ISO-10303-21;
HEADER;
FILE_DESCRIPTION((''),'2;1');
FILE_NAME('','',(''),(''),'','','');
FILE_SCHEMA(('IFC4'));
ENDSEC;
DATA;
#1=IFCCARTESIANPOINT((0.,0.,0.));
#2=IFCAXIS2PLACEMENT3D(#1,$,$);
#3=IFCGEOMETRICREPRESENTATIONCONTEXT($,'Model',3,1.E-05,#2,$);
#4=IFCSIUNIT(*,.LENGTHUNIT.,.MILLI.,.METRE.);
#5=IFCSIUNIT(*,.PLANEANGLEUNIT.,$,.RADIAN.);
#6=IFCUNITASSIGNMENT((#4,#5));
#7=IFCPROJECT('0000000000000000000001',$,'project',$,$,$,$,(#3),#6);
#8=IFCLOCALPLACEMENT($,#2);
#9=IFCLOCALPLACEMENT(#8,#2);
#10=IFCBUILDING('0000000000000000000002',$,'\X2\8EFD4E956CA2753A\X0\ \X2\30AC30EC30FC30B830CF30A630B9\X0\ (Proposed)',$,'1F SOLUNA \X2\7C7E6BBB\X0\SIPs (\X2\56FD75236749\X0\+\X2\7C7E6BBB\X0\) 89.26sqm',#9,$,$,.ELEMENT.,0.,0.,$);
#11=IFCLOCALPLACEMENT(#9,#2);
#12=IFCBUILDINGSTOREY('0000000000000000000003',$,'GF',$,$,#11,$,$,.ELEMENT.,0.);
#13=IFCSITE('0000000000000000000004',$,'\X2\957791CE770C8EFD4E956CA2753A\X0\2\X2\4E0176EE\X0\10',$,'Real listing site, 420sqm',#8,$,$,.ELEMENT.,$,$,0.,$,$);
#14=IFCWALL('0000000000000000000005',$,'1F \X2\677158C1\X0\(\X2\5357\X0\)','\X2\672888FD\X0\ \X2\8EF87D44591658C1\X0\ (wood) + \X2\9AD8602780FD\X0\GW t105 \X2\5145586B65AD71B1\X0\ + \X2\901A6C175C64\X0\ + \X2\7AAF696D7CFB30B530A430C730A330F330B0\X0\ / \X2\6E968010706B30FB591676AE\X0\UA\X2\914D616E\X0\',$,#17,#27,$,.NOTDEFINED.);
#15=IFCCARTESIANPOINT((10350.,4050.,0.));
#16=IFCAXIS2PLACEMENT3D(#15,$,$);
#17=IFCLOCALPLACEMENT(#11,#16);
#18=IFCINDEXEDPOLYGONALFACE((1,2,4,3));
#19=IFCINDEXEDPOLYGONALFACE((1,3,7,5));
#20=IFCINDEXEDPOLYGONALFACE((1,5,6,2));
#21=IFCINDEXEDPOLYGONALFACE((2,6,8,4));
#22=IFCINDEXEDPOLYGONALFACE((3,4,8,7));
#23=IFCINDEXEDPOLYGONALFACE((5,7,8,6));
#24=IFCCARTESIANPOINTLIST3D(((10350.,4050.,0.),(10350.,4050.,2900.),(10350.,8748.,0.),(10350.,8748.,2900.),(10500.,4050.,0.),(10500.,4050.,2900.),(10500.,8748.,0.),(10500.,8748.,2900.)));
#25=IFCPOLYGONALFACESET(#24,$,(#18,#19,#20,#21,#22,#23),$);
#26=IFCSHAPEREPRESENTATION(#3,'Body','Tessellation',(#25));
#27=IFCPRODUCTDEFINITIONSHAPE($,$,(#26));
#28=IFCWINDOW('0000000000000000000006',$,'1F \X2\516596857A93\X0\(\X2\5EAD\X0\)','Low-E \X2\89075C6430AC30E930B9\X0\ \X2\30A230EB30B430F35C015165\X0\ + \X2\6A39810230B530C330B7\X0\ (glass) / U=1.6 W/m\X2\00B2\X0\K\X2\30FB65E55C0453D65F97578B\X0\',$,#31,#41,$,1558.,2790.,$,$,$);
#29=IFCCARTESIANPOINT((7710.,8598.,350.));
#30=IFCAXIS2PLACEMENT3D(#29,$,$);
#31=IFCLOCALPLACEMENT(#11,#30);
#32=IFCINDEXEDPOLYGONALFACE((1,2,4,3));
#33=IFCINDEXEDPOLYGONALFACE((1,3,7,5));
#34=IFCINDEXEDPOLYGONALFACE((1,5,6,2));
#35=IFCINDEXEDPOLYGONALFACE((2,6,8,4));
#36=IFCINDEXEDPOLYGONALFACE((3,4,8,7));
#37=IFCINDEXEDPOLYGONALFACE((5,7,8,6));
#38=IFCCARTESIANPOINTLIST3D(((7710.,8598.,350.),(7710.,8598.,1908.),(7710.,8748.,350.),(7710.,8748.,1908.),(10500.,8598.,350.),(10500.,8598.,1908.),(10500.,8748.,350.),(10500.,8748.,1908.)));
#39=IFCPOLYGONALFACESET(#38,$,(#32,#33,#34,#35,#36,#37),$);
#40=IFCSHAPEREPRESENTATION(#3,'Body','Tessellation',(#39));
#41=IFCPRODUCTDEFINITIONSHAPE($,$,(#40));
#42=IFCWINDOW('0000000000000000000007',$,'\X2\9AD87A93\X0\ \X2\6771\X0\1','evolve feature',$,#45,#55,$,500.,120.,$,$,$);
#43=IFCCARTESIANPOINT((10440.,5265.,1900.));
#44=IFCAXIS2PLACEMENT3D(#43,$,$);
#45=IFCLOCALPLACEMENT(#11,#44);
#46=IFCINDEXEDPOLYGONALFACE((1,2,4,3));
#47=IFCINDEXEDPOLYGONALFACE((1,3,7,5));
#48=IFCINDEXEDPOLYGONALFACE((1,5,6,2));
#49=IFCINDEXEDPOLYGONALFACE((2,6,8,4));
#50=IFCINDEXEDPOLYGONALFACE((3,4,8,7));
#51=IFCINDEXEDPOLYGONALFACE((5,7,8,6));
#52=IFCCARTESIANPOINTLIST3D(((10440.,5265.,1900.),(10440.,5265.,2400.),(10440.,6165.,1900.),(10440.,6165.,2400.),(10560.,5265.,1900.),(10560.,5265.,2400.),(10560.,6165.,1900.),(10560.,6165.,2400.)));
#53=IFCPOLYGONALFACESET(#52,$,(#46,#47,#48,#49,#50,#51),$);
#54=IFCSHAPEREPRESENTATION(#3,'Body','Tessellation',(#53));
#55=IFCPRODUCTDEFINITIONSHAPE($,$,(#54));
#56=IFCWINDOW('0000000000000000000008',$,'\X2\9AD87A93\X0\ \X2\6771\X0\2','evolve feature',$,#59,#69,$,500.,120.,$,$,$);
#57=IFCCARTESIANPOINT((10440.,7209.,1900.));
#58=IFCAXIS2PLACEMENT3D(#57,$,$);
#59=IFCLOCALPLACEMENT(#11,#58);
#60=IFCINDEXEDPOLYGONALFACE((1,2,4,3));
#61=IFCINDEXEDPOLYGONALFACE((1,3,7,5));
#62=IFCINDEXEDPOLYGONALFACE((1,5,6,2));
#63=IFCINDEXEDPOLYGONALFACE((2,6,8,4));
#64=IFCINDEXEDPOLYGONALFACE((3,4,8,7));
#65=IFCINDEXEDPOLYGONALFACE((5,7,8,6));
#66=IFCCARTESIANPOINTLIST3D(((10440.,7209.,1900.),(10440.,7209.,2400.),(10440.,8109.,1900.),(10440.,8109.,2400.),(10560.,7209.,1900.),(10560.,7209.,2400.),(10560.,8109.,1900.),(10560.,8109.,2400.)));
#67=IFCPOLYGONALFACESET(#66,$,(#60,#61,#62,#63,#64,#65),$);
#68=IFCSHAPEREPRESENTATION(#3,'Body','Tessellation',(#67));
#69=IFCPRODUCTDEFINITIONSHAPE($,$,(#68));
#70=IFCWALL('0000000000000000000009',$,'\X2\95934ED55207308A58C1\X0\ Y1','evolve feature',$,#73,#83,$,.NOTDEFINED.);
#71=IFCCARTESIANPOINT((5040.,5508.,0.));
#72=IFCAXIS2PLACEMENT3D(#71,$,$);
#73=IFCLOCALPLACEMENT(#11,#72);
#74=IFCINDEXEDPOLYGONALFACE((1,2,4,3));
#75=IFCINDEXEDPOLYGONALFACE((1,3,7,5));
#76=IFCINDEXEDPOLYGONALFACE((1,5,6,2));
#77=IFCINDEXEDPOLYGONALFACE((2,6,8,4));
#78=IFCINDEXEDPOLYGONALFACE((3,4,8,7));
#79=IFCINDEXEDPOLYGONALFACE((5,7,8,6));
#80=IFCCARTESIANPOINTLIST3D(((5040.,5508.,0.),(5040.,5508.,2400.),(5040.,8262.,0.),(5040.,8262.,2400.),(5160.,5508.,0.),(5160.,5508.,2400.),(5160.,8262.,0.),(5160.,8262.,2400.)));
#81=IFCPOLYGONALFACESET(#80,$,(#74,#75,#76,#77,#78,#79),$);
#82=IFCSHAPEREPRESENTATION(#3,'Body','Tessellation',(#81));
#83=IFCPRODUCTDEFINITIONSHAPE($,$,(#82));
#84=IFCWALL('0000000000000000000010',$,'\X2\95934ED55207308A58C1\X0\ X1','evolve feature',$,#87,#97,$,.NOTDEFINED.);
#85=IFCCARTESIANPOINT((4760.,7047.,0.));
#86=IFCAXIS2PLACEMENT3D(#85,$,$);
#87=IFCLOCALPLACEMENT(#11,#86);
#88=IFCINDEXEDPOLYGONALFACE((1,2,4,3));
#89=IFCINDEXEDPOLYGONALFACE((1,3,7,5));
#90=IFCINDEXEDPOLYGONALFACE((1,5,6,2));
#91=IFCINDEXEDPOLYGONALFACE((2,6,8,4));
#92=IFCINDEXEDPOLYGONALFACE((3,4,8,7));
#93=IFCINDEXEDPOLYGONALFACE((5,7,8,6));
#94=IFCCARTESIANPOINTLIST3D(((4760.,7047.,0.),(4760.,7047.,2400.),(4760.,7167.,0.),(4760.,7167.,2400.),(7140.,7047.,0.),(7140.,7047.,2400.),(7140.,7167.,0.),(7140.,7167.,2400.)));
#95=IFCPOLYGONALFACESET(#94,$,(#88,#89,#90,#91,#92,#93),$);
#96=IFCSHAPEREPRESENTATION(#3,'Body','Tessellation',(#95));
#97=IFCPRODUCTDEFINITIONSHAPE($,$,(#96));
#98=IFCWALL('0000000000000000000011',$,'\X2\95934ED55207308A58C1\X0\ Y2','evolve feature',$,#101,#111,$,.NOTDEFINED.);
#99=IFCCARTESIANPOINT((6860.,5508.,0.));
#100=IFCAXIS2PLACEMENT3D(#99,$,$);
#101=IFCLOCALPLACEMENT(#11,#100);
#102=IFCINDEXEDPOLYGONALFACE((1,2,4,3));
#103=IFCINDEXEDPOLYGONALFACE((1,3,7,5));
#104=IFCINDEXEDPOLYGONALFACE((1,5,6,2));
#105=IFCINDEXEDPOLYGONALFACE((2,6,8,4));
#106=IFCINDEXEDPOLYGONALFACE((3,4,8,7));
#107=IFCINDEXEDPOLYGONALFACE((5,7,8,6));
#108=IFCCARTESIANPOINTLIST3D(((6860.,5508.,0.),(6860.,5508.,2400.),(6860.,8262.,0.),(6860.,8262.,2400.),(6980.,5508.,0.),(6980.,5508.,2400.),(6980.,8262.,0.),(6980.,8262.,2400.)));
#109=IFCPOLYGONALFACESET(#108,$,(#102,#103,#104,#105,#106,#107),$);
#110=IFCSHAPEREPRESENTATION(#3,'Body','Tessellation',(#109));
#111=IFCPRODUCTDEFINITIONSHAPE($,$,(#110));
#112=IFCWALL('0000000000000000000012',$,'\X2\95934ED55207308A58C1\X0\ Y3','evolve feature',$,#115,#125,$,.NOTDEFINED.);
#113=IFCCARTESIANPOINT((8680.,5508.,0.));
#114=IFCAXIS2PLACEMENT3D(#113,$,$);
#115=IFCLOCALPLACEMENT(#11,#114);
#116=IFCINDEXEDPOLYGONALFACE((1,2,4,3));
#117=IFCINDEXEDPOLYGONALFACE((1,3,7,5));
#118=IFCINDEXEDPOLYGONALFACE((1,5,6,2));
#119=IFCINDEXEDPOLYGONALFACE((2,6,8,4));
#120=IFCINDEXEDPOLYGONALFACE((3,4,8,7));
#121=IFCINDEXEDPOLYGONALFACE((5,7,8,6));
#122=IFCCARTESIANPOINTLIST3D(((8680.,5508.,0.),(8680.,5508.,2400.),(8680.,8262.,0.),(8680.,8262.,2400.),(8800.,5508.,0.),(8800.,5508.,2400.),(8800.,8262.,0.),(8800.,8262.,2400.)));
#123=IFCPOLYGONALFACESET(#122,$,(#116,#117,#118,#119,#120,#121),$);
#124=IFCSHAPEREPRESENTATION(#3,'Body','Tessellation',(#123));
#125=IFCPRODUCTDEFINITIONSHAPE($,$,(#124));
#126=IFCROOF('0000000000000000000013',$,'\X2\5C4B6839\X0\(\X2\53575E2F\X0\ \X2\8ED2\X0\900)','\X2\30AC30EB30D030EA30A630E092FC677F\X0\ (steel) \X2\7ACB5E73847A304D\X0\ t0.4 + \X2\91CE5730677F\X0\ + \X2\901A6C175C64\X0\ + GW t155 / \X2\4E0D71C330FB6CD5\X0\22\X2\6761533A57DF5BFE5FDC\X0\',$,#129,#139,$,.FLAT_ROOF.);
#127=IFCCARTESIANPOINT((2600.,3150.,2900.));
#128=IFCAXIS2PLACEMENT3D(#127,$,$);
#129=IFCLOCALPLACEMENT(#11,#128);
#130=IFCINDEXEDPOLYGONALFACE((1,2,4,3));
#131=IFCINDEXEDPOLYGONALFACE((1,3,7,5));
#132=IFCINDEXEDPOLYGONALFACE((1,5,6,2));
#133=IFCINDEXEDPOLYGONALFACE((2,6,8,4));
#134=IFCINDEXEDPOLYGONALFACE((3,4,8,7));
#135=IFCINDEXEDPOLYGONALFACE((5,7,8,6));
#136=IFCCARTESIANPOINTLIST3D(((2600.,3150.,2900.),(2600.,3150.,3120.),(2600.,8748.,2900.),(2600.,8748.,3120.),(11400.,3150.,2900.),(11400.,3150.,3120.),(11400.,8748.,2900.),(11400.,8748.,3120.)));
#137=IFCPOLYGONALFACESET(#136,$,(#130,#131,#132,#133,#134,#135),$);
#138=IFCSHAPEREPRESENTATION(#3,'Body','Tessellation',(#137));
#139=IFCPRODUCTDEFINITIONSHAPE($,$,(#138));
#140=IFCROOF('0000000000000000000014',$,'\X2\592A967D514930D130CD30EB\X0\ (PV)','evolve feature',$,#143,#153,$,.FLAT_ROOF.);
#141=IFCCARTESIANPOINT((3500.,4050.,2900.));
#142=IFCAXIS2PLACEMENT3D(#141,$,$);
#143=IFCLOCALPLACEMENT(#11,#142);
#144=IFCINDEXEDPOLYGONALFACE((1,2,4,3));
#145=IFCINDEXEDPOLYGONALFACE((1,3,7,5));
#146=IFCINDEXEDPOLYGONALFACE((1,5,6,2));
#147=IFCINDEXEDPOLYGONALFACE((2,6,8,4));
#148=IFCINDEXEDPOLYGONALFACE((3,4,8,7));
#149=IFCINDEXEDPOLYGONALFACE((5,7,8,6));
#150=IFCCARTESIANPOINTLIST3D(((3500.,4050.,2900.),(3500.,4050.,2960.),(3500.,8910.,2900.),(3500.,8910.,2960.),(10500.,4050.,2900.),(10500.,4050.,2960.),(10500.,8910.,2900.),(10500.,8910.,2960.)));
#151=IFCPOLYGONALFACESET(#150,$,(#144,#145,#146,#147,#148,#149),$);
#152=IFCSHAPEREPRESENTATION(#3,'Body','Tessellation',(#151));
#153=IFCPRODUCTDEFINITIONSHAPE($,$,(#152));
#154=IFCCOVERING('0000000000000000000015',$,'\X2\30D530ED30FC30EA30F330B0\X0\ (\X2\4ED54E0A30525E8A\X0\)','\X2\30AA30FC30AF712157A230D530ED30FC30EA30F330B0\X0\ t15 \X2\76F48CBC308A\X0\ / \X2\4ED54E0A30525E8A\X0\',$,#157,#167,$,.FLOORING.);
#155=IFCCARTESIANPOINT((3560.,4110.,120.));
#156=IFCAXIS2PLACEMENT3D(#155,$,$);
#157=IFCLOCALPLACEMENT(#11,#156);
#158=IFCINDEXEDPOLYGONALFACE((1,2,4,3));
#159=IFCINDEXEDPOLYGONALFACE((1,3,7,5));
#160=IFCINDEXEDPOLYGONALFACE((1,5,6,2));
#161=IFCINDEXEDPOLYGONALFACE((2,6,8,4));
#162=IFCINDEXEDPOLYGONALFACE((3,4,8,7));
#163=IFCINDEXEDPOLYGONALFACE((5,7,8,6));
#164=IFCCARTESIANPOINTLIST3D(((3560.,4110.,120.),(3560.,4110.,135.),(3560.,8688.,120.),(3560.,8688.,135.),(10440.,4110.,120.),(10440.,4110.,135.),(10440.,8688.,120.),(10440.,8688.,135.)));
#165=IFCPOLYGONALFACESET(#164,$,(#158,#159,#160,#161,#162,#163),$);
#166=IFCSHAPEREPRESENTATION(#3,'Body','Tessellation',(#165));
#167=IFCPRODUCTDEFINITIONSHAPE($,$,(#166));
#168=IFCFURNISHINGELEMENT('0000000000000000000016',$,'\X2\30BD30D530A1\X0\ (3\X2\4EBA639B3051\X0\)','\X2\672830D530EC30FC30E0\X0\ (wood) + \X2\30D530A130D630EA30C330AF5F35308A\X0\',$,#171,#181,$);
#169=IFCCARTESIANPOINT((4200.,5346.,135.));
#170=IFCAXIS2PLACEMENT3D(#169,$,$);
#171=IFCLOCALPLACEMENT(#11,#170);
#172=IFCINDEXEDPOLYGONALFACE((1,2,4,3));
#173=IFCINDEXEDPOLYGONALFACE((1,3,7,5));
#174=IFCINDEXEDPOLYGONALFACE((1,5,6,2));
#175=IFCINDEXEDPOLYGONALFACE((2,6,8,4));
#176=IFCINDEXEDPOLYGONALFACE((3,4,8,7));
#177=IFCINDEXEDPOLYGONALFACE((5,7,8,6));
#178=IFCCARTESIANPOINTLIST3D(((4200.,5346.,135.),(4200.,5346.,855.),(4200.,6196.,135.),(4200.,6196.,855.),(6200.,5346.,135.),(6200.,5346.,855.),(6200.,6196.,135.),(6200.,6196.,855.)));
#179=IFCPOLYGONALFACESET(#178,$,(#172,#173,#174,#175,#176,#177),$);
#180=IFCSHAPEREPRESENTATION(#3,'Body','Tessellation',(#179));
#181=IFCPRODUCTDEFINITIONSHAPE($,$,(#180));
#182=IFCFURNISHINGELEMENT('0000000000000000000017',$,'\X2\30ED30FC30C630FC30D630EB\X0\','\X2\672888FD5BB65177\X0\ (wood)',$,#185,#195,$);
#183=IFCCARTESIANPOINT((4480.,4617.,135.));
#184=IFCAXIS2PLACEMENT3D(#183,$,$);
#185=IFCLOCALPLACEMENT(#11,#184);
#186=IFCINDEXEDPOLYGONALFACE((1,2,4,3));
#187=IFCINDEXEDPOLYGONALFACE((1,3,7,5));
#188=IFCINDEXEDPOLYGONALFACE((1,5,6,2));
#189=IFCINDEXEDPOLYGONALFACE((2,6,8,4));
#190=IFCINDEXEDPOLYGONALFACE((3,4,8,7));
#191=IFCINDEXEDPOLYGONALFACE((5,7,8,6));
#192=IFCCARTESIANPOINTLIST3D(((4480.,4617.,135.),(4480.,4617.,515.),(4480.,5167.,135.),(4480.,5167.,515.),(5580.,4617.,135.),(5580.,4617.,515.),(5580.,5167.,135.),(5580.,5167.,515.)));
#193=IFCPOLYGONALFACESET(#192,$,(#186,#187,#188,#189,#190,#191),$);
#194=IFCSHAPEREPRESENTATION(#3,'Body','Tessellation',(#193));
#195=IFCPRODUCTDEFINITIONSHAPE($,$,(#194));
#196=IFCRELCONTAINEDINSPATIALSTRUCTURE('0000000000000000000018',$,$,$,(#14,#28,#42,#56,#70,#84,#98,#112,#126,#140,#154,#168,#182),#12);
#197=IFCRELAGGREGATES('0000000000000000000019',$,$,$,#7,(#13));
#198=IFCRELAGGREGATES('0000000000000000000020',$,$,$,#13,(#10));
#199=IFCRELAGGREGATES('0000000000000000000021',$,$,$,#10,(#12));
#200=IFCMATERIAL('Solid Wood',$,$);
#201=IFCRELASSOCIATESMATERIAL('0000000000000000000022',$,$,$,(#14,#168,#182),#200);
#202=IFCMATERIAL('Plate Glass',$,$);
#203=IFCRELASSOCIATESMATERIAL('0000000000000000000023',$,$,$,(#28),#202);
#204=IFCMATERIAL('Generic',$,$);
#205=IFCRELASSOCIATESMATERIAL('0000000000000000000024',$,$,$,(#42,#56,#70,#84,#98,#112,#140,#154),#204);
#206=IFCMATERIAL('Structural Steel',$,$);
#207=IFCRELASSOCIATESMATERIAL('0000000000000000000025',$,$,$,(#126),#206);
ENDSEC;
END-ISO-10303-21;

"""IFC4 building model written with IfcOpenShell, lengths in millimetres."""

from ifc_helpers import new_model, si_unit, frame, frame_2d, origin, place, context, project, spatial, rectangle, extrude, material, element, fill, save


model = new_model("IFC4")

# Units and contexts
model_context = context("Model", 3, precision=1e-05, world=origin())
ifc_project = project(units=[si_unit("LENGTHUNIT", "METRE", prefix="MILLI"), si_unit("PLANEANGLEUNIT", "RADIAN")], contexts=[model_context])

# Site, building, storey
site_placement = place(None, origin())
site = spatial("IfcSite", under=ifc_project, at=site_placement, Name="長野県軽井沢町2丁目10", ObjectType="Real listing site, 420sqm", CompositionType="ELEMENT", RefElevation=0.0)
building_placement = place(site_placement, origin())
building = spatial("IfcBuilding", under=site, at=building_placement, Name="軽井沢町 ガレージハウス (Proposed)", ObjectType="1F SOLUNA 籾殻SIPs (国産杉+籾殻) 89.26sqm", CompositionType="ELEMENT", ElevationOfRefHeight=0.0, ElevationOfTerrain=0.0)
storey_placement = place(building_placement, origin())
storey = spatial("IfcBuildingStorey", under=building, at=storey_placement, Name="GF", CompositionType="ELEMENT", Elevation=0.0)

# Shared definitions
ifc_material_1 = material(Name="Solid Wood")
ifc_material_2 = material(Name="Generic")

# Shared definitions
ifc_material_3 = material(Name="Plate Glass")

# Wall, openings, windows
wall_1_placement = place(storey_placement, frame((10350.0, 4050.0, 0.0)))
wall_1 = element("IfcWall", 1, at=wall_1_placement, inside=storey, material=ifc_material_1, Name="1F 東壁(南)", Description="木製 軸組外壁 (wood) + 高性能GW t105 充填断熱 + 通気層 + 窯業系サイディング / 準耐火・外皮UA配慮", PredefinedType="NOTDEFINED", context=model_context, shape_type="SweptSolid", body=[
    extrude(rectangle(XDim=150.0, YDim=4698.0, at=frame_2d((75.0, 2349.0))), frame((10350.0, 4050.0, 0.0)), (0.0, 0.0, 1.0), 2900.0),
])
opening_1_placement = place(storey_placement, frame((7710.0, 8598.0, 350.0)))
opening_1 = element("IfcOpeningElement", 2, at=opening_1_placement, cuts=wall_1, PredefinedType="NOTDEFINED", context=model_context, shape_type="SweptSolid", body=[
    extrude(rectangle(XDim=2790.0, YDim=150.0, at=frame_2d((1395.0, 75.0))), frame((7710.0, 8598.0, 350.0)), (0.0, 0.0, 1.0), 1558.0),
])
opening_2_placement = place(storey_placement, frame((10440.0, 5265.0, 1900.0)))
opening_2 = element("IfcOpeningElement", 3, at=opening_2_placement, cuts=wall_1, PredefinedType="NOTDEFINED", context=model_context, shape_type="SweptSolid", body=[
    extrude(rectangle(XDim=120.0, YDim=900.0, at=frame_2d((60.0, 450.0))), frame((10440.0, 5265.0, 1900.0)), (0.0, 0.0, 1.0), 500.0),
])
opening_3_placement = place(storey_placement, frame((10440.0, 7209.0, 1900.0)))
opening_3 = element("IfcOpeningElement", 4, at=opening_3_placement, cuts=wall_1, PredefinedType="NOTDEFINED", context=model_context, shape_type="SweptSolid", body=[
    extrude(rectangle(XDim=120.0, YDim=900.0, at=frame_2d((60.0, 450.0))), frame((10440.0, 7209.0, 1900.0)), (0.0, 0.0, 1.0), 500.0),
])
window_1_placement = place(storey_placement, frame((7710.0, 8598.0, 350.0)))
window_1 = element("IfcWindow", 5, at=window_1_placement, inside=storey, material=ifc_material_3, Name="1F 入隅窓(庭)", Description="Low-E 複層ガラス アルゴン封入 + 樹脂サッシ (glass) / U=1.6 W/m²K・日射取得型", OverallHeight=1558.0, OverallWidth=2790.0, context=model_context, shape_type="SweptSolid", body=[
    extrude(rectangle(XDim=2790.0, YDim=150.0, at=frame_2d((1395.0, 75.0))), frame((7710.0, 8598.0, 350.0)), (0.0, 0.0, 1.0), 1558.0),
])
fill(opening_1, window_1)
window_2_placement = place(storey_placement, frame((10440.0, 5265.0, 1900.0)))
window_2 = element("IfcWindow", 6, at=window_2_placement, inside=storey, material=ifc_material_2, Name="高窓 東1", Description="evolve feature", OverallHeight=500.0, OverallWidth=120.0, context=model_context, shape_type="SweptSolid", body=[
    extrude(rectangle(XDim=120.0, YDim=900.0, at=frame_2d((60.0, 450.0))), frame((10440.0, 5265.0, 1900.0)), (0.0, 0.0, 1.0), 500.0),
])
fill(opening_2, window_2)
window_3_placement = place(storey_placement, frame((10440.0, 7209.0, 1900.0)))
window_3 = element("IfcWindow", 7, at=window_3_placement, inside=storey, material=ifc_material_2, Name="高窓 東2", Description="evolve feature", OverallHeight=500.0, OverallWidth=120.0, context=model_context, shape_type="SweptSolid", body=[
    extrude(rectangle(XDim=120.0, YDim=900.0, at=frame_2d((60.0, 450.0))), frame((10440.0, 7209.0, 1900.0)), (0.0, 0.0, 1.0), 500.0),
])
fill(opening_3, window_3)

# Walls
wall_2_placement = place(storey_placement, frame((5040.0, 5508.0, 0.0)))
element("IfcWall", 8, at=wall_2_placement, inside=storey, material=ifc_material_2, Name="間仕切り壁 Y1", Description="evolve feature", PredefinedType="NOTDEFINED", context=model_context, shape_type="SweptSolid", body=[
    extrude(rectangle(XDim=120.0, YDim=2754.0, at=frame_2d((60.0, 1377.0))), frame((5040.0, 5508.0, 0.0)), (0.0, 0.0, 1.0), 2400.0),
])
wall_3_placement = place(storey_placement, frame((4760.0, 7047.0, 0.0)))
element("IfcWall", 9, at=wall_3_placement, inside=storey, material=ifc_material_2, Name="間仕切り壁 X1", Description="evolve feature", PredefinedType="NOTDEFINED", context=model_context, shape_type="SweptSolid", body=[
    extrude(rectangle(XDim=2380.0, YDim=120.0, at=frame_2d((1190.0, 60.0))), frame((4760.0, 7047.0, 0.0)), (0.0, 0.0, 1.0), 2400.0),
])
wall_4_placement = place(storey_placement, frame((6860.0, 5508.0, 0.0)))
element("IfcWall", 10, at=wall_4_placement, inside=storey, material=ifc_material_2, Name="間仕切り壁 Y2", Description="evolve feature", PredefinedType="NOTDEFINED", context=model_context, shape_type="SweptSolid", body=[
    extrude(rectangle(XDim=120.0, YDim=2754.0, at=frame_2d((60.0, 1377.0))), frame((6860.0, 5508.0, 0.0)), (0.0, 0.0, 1.0), 2400.0),
])
wall_5_placement = place(storey_placement, frame((8680.0, 5508.0, 0.0)))
element("IfcWall", 11, at=wall_5_placement, inside=storey, material=ifc_material_2, Name="間仕切り壁 Y3", Description="evolve feature", PredefinedType="NOTDEFINED", context=model_context, shape_type="SweptSolid", body=[
    extrude(rectangle(XDim=120.0, YDim=2754.0, at=frame_2d((60.0, 1377.0))), frame((8680.0, 5508.0, 0.0)), (0.0, 0.0, 1.0), 2400.0),
])

# Roofs
ifc_material_4 = material(Name="Structural Steel")
roof_1_placement = place(storey_placement, frame((2600.0, 3150.0, 2900.0)))
element("IfcRoof", 12, at=roof_1_placement, inside=storey, material=ifc_material_4, Name="屋根(南帯 軒900)", Description="ガルバリウム鋼板 (steel) 立平葺き t0.4 + 野地板 + 通気層 + GW t155 / 不燃・法22条区域対応", PredefinedType="FLAT_ROOF", context=model_context, shape_type="SweptSolid", body=[
    extrude(rectangle(XDim=8800.0, YDim=5598.0, at=frame_2d((4400.0, 2799.0))), frame((2600.0, 3150.0, 2900.0)), (0.0, 0.0, 1.0), 220.0),
])
roof_2_placement = place(storey_placement, frame((3500.0, 4050.0, 2900.0)))
element("IfcRoof", 13, at=roof_2_placement, inside=storey, material=ifc_material_2, Name="太陽光パネル (PV)", Description="evolve feature", PredefinedType="FLAT_ROOF", context=model_context, shape_type="SweptSolid", body=[
    extrude(rectangle(XDim=7000.0, YDim=4860.0, at=frame_2d((3500.0, 2430.0))), frame((3500.0, 4050.0, 2900.0)), (0.0, 0.0, 1.0), 60.0),
])

# Covering
covering_placement = place(storey_placement, frame((3560.0, 4110.0, 120.0)))
element("IfcCovering", 14, at=covering_placement, inside=storey, material=ifc_material_2, Name="フローリング (仕上げ床)", Description="オーク無垢フローリング t15 直貼り / 仕上げ床", PredefinedType="FLOORING", context=model_context, shape_type="SweptSolid", body=[
    extrude(rectangle(XDim=6880.0, YDim=4578.0, at=frame_2d((3440.0, 2289.0))), frame((3560.0, 4110.0, 120.0)), (0.0, 0.0, 1.0), 15.0),
])

# Furnishing elements
furnishing_1_placement = place(storey_placement, frame((4200.0, 5346.0, 135.0)))
element("IfcFurnishingElement", 15, at=furnishing_1_placement, inside=storey, material=ifc_material_1, Name="ソファ (3人掛け)", Description="木フレーム (wood) + ファブリック張り", context=model_context, shape_type="SweptSolid", body=[
    extrude(rectangle(XDim=2000.0, YDim=850.0, at=frame_2d((1000.0, 425.0))), frame((4200.0, 5346.0, 135.0)), (0.0, 0.0, 1.0), 720.0),
])
furnishing_2_placement = place(storey_placement, frame((4480.0, 4617.0, 135.0)))
element("IfcFurnishingElement", 16, at=furnishing_2_placement, inside=storey, material=ifc_material_1, Name="ローテーブル", Description="木製家具 (wood)", context=model_context, shape_type="SweptSolid", body=[
    extrude(rectangle(XDim=1100.0, YDim=550.0, at=frame_2d((550.0, 275.0))), frame((4480.0, 4617.0, 135.0)), (0.0, 0.0, 1.0), 380.0),
])

save(model, "model.ifc")
